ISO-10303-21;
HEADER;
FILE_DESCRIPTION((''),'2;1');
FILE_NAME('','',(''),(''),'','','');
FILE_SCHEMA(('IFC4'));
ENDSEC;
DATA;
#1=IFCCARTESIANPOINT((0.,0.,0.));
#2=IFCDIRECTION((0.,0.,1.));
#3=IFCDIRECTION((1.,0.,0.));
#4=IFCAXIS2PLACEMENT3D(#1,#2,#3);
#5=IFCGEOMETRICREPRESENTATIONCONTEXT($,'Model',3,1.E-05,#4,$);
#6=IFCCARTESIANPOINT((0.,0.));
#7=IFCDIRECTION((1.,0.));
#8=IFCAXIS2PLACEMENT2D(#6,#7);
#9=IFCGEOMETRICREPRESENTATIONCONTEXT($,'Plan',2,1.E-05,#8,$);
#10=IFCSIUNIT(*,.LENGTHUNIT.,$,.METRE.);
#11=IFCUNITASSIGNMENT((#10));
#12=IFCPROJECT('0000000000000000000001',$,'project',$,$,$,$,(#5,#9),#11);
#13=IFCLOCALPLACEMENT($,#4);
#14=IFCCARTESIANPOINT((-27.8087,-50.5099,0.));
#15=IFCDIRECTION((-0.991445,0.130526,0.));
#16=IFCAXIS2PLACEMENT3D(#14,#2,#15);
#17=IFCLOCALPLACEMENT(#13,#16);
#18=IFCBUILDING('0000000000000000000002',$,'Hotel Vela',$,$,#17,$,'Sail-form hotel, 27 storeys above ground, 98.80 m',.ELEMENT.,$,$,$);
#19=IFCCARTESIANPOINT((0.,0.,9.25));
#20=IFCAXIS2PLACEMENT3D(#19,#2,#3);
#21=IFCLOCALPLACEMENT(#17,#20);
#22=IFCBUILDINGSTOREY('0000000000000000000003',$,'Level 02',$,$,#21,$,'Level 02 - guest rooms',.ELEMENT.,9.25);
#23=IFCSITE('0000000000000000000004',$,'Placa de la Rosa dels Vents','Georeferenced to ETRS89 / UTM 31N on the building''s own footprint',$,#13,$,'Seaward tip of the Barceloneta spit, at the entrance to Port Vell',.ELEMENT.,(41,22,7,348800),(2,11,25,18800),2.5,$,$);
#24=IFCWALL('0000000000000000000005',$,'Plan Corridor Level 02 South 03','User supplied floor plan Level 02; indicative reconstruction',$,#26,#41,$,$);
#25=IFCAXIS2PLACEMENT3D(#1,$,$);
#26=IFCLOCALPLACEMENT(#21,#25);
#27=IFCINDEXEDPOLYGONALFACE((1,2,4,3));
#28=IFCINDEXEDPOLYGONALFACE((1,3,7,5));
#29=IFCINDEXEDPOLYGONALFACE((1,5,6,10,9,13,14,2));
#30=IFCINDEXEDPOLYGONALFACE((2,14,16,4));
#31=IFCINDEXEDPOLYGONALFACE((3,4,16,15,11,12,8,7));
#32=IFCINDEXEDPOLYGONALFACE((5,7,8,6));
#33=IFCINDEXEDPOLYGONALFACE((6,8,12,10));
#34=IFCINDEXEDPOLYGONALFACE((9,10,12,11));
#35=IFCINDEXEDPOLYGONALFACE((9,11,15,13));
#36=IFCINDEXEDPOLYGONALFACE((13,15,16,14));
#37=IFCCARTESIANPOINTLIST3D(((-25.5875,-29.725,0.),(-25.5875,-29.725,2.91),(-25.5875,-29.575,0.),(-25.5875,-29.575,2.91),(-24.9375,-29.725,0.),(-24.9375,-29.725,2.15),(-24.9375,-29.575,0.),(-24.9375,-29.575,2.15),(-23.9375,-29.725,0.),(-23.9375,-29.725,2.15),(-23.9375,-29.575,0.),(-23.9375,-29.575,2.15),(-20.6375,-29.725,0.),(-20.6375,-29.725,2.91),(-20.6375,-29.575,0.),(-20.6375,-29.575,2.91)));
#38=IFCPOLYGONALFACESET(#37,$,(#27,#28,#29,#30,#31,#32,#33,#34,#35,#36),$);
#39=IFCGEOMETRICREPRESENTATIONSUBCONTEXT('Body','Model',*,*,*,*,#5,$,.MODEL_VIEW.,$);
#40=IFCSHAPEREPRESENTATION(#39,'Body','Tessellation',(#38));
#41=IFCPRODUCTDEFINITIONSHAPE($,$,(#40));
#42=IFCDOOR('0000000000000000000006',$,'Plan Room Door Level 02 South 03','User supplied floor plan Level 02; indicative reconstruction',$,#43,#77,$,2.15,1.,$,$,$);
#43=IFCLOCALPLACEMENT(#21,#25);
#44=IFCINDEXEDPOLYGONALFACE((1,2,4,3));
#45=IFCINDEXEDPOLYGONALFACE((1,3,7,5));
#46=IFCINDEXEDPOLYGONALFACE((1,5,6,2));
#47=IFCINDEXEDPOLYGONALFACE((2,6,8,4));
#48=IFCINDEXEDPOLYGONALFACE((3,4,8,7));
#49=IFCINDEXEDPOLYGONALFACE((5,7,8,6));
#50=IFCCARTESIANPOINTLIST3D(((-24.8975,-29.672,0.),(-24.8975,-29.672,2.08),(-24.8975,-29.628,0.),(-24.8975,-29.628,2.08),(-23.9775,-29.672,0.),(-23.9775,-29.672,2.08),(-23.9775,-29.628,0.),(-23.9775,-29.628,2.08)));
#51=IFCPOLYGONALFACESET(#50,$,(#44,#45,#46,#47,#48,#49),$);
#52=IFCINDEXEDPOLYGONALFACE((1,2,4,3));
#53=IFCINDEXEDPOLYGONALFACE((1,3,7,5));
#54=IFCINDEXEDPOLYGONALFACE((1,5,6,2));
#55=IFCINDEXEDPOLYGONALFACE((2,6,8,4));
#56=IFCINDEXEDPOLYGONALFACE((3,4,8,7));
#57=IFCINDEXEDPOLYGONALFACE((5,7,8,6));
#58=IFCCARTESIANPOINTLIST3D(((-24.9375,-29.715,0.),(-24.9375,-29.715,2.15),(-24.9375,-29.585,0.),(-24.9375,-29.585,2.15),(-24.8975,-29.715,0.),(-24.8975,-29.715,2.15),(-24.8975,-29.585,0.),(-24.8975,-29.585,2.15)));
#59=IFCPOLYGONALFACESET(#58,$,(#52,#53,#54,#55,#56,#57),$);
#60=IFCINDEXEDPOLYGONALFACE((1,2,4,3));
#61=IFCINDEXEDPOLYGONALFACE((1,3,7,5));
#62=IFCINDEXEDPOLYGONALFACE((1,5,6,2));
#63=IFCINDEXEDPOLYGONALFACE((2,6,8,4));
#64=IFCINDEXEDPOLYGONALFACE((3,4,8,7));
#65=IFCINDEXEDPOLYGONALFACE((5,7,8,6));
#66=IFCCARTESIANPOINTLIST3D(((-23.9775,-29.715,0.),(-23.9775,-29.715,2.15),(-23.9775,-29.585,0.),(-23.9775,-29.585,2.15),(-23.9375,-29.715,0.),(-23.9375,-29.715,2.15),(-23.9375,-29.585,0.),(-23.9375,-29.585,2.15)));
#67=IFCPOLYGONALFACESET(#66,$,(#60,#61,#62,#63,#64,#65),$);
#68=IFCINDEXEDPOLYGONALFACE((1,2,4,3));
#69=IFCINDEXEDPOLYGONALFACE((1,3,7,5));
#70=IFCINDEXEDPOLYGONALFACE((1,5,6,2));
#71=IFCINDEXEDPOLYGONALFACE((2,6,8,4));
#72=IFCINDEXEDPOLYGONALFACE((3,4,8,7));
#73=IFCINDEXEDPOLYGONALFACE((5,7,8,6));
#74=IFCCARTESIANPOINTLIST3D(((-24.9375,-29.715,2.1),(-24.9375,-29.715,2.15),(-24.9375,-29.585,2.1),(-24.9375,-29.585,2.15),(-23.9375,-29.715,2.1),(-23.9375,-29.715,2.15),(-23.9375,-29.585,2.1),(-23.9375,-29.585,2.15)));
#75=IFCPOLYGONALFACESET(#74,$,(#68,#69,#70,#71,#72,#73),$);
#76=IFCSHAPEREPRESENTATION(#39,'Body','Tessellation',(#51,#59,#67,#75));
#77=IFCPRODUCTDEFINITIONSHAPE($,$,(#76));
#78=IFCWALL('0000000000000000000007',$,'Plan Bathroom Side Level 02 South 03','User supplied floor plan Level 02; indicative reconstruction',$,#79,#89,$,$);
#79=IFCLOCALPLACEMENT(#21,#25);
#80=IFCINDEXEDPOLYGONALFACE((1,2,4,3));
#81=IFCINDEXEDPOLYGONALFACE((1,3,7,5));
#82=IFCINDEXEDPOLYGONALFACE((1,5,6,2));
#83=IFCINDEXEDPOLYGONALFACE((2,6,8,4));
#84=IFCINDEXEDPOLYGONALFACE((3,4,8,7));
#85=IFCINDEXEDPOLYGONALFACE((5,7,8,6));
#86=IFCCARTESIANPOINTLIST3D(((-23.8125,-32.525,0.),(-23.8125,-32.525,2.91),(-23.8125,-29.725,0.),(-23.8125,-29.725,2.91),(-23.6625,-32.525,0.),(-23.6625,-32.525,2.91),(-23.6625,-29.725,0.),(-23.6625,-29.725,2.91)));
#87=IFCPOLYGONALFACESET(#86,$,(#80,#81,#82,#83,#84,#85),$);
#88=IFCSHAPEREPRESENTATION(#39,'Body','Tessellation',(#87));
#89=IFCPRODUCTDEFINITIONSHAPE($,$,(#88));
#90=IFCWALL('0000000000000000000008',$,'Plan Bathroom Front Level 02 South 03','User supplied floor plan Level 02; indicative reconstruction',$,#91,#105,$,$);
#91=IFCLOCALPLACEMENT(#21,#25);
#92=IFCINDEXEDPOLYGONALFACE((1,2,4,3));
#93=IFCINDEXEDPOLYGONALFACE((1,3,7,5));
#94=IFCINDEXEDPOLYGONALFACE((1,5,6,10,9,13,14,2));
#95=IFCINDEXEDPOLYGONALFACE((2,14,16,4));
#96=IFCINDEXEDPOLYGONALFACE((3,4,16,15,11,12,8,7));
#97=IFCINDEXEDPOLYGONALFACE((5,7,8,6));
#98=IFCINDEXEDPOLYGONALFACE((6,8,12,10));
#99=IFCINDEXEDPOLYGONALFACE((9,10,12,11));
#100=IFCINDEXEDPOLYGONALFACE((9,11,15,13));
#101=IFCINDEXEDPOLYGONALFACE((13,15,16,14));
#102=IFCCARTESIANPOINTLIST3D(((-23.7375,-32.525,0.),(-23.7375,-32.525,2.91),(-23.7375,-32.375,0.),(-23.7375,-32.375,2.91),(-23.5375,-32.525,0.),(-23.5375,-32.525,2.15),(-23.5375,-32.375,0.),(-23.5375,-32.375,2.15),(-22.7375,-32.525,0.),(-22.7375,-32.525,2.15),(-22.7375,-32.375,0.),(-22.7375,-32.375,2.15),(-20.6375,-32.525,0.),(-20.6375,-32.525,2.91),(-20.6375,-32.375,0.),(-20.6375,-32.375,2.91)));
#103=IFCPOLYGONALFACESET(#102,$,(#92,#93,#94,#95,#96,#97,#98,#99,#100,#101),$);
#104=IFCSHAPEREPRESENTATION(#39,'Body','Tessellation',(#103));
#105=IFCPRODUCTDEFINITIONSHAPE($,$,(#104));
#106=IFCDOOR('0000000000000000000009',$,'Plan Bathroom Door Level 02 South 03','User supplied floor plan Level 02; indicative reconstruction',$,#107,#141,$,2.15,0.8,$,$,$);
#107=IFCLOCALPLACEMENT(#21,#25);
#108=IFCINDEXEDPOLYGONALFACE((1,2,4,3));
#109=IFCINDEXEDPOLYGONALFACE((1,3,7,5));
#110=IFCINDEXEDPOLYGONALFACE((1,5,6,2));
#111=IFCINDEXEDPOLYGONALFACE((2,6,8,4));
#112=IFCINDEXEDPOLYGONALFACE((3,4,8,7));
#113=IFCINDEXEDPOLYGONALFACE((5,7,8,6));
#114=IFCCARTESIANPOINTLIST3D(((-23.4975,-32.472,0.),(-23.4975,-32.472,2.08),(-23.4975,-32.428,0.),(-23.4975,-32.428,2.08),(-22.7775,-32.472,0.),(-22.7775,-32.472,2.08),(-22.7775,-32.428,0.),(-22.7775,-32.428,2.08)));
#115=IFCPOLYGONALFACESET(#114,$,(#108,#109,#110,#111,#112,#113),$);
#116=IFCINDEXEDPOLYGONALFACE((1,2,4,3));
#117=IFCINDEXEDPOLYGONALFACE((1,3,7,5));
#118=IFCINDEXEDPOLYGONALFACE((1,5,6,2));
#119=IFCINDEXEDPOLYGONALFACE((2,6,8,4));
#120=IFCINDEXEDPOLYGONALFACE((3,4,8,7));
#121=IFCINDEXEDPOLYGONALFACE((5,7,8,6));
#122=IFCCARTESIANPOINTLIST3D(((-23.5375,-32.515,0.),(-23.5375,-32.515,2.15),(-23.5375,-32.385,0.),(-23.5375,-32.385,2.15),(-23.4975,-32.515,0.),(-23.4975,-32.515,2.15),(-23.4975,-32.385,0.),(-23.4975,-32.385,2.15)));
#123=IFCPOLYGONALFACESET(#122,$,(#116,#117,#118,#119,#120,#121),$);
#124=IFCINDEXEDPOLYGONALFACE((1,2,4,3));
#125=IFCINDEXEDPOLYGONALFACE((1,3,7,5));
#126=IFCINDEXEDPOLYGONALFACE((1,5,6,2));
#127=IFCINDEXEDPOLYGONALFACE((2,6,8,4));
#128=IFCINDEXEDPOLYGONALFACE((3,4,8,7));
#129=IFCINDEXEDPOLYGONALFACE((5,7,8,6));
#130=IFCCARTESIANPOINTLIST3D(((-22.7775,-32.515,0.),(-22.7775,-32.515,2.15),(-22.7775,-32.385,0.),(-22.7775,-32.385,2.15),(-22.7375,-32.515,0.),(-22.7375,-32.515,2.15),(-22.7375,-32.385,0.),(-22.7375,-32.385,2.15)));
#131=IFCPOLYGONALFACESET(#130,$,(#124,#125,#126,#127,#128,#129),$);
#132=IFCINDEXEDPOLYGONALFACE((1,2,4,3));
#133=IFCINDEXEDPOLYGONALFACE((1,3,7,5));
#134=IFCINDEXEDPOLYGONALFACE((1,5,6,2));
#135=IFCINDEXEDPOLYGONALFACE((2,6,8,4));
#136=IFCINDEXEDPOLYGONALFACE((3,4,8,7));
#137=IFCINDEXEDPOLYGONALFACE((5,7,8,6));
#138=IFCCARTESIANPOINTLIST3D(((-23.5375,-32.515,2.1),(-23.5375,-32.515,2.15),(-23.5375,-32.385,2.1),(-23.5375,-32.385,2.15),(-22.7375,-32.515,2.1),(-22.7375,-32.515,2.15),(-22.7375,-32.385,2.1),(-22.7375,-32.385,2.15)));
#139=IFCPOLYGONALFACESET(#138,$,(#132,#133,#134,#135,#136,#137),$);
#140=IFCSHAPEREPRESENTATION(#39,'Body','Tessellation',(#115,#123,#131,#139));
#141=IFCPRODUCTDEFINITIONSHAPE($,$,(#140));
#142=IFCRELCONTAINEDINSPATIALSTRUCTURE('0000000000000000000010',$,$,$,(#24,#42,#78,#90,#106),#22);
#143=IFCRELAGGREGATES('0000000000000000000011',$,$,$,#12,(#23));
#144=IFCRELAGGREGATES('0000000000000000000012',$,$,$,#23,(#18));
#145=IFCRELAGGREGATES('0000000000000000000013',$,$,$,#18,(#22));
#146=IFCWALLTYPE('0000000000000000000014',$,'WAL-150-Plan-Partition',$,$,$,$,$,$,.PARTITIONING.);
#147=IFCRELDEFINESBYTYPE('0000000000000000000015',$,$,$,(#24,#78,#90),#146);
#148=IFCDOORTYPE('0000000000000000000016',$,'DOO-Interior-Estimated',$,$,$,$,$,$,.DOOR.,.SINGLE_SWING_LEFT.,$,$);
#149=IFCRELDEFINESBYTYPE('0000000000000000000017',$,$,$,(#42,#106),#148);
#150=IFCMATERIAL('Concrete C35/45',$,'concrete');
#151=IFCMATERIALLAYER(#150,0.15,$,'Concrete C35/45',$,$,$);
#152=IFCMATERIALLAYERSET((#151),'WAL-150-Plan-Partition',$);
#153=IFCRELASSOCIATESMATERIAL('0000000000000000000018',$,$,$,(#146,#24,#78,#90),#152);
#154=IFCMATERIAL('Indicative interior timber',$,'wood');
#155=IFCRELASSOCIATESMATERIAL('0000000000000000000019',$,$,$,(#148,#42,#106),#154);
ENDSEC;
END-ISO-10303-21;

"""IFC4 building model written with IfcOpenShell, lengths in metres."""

from ifc_helpers import new_model, si_unit, frame, origin_with_axes, origin_2d_with_axis, place, context, subcontext, project, spatial, line, indexed_curve, outline, extrude, material, layer, layer_set, layer_usage, type_object, element, fill, save


model = new_model("IFC4")

# Units and contexts
model_context = context("Model", 3, precision=1e-05, world=origin_with_axes())
plan_context = context("Plan", 2, precision=1e-05, world=origin_2d_with_axis())
body_context = subcontext(model_context, "Body", "Model", "MODEL_VIEW")
ifc_project = project(units=[si_unit("LENGTHUNIT", "METRE")], contexts=[model_context, plan_context])

# Site, building, storey
site_placement = place(None, origin_with_axes())
site = spatial("IfcSite", under=ifc_project, at=site_placement, Name="Placa de la Rosa dels Vents", Description="Georeferenced to ETRS89 / UTM 31N on the building's own footprint", LongName="Seaward tip of the Barceloneta spit, at the entrance to Port Vell", CompositionType="ELEMENT", RefLatitude=(41, 22, 7, 348800), RefLongitude=(2, 11, 25, 18800), RefElevation=2.5)
building_placement = place(site_placement, frame((-27.8087, -50.5099, 0.0), z_axis=(0.0, 0.0, 1.0), x_axis=(-0.991445, 0.130526, 0.0)))
building = spatial("IfcBuilding", under=site, at=building_placement, Name="Hotel Vela", LongName="Sail-form hotel, 27 storeys above ground, 98.80 m", CompositionType="ELEMENT")
storey_placement = place(building_placement, frame((0.0, 0.0, 9.25), z_axis=(0.0, 0.0, 1.0), x_axis=(1.0, 0.0, 0.0)))
storey = spatial("IfcBuildingStorey", under=building, at=storey_placement, Name="Level 02", LongName="Level 02 - guest rooms", CompositionType="ELEMENT", Elevation=9.25)

# Wall, opening, door
ifc_material_1 = material(Name="Concrete C35/45", Category="concrete")
ifc_layer = layer(ifc_material_1, 0.15, Name="Concrete C35/45")
ifc_layer_set = layer_set([ifc_layer], Name="WAL-150-Plan-Partition")
ifc_layer_usage_1 = layer_usage(ifc_layer_set, "AXIS2", "POSITIVE", 0.0)
wall_type = type_object("IfcWallType", Name="WAL-150-Plan-Partition", PredefinedType="PARTITIONING", material=ifc_layer_set)
wall_1_placement = place(storey_placement, frame((-25.5875, -29.725, 0.0), z_axis=(0.0, 0.0, 1.0), x_axis=(1.0, 0.0, 0.0)))
wall_1 = element("IfcWall", 1, at=wall_1_placement, inside=storey, type_object=wall_type, material=ifc_layer_usage_1, Name="Plan Corridor Level 02 South 03", Description="User supplied floor plan Level 02; indicative reconstruction", context=body_context, shape_type="SweptSolid", body=[
    extrude(outline(indexed_curve([(0.0, 0.0), (4.95, 0.0), (4.95, 0.15), (0.0, 0.15)], segments=[line(1, 2, 3, 4, 1)])), origin_with_axes(), (0.0, 0.0, 1.0), 2.91),
])
opening_1_placement = place(wall_1_placement, frame((0.65, -0.085, 0.0), z_axis=(0.0, 0.0, 1.0), x_axis=(1.0, 0.0, 0.0)))
opening_1 = element("IfcOpeningElement", 2, at=opening_1_placement, cuts=wall_1, PredefinedType="OPENING", context=body_context, shape_type="SweptSolid", body=[
    extrude(outline(indexed_curve([(0.0, 0.0), (1.0, 0.0), (1.0, 0.32), (0.0, 0.32)], segments=[line(1, 2, 3, 4, 1)])), origin_with_axes(), (0.0, 0.0, 1.0), 2.15),
])
ifc_material_2 = material(Name="Indicative interior timber", Category="wood")
door_type = type_object("IfcDoorType", Name="DOO-Interior-Estimated", OperationType="SINGLE_SWING_LEFT", PredefinedType="DOOR", material=ifc_material_2)
door_1_placement = place(storey_placement, frame((0.0, 0.0, -9.25), z_axis=(0.0, 0.0, 1.0), x_axis=(1.0, 0.0, 0.0)))
door_1 = element("IfcDoor", 3, at=door_1_placement, inside=storey, type_object=door_type, material=ifc_material_2, Name="Plan Room Door Level 02 South 03", Description="User supplied floor plan Level 02; indicative reconstruction", OverallHeight=2.15, OverallWidth=1.0, context=body_context, shape_type="SweptSolid", body=[
    extrude(outline(indexed_curve([(0.0, 0.0), (0.92, 0.0), (0.92, 0.044), (0.0, 0.044)], segments=[line(1, 2, 3, 4, 1)])), frame((-24.8975, -29.672, 9.25), z_axis=(0.0, 0.0, 1.0), x_axis=(1.0, 0.0, 0.0)), (0.0, 0.0, 1.0), 2.08),
    extrude(outline(indexed_curve([(0.0, 0.0), (0.04, 0.0), (0.04, 0.13), (0.0, 0.13)], segments=[line(1, 2, 3, 4, 1)])), frame((-24.9375, -29.715, 9.25), z_axis=(0.0, 0.0, 1.0), x_axis=(1.0, 0.0, 0.0)), (0.0, 0.0, 1.0), 2.15),
    extrude(outline(indexed_curve([(0.0, 0.0), (0.04, 0.0), (0.04, 0.13), (0.0, 0.13)], segments=[line(1, 2, 3, 4, 1)])), frame((-23.9775, -29.715, 9.25), z_axis=(0.0, 0.0, 1.0), x_axis=(1.0, 0.0, 0.0)), (0.0, 0.0, 1.0), 2.15),
    extrude(outline(indexed_curve([(0.0, 0.0), (1.0, 0.0), (1.0, 0.13), (0.0, 0.13)], segments=[line(1, 2, 3, 4, 1)])), frame((-24.9375, -29.715, 11.35), z_axis=(0.0, 0.0, 1.0), x_axis=(1.0, 0.0, 0.0)), (0.0, 0.0, 1.0), 0.05),
])
fill(opening_1, door_1)

# Wall
ifc_layer_usage_2 = layer_usage(ifc_layer_set, "AXIS2", "POSITIVE", 0.0)
wall_2_placement = place(storey_placement, frame((-23.8125, -32.525, 0.0), z_axis=(0.0, 0.0, 1.0), x_axis=(1.0, 0.0, 0.0)))
element("IfcWall", 4, at=wall_2_placement, inside=storey, type_object=wall_type, material=ifc_layer_usage_2, Name="Plan Bathroom Side Level 02 South 03", Description="User supplied floor plan Level 02; indicative reconstruction", context=body_context, shape_type="SweptSolid", body=[
    extrude(outline(indexed_curve([(0.0, 0.0), (0.15, 0.0), (0.15, 2.8), (0.0, 2.8)], segments=[line(1, 2, 3, 4, 1)])), origin_with_axes(), (0.0, 0.0, 1.0), 2.91),
])

# Wall, opening, door
ifc_layer_usage_3 = layer_usage(ifc_layer_set, "AXIS2", "POSITIVE", 0.0)
wall_3_placement = place(storey_placement, frame((-23.7375, -32.525, 0.0), z_axis=(0.0, 0.0, 1.0), x_axis=(1.0, 0.0, 0.0)))
wall_3 = element("IfcWall", 5, at=wall_3_placement, inside=storey, type_object=wall_type, material=ifc_layer_usage_3, Name="Plan Bathroom Front Level 02 South 03", Description="User supplied floor plan Level 02; indicative reconstruction", context=body_context, shape_type="SweptSolid", body=[
    extrude(outline(indexed_curve([(0.0, 0.0), (3.1, 0.0), (3.1, 0.15), (0.0, 0.15)], segments=[line(1, 2, 3, 4, 1)])), origin_with_axes(), (0.0, 0.0, 1.0), 2.91),
])
opening_2_placement = place(wall_3_placement, frame((0.2, -0.085, 0.0), z_axis=(0.0, 0.0, 1.0), x_axis=(1.0, 0.0, 0.0)))
opening_2 = element("IfcOpeningElement", 6, at=opening_2_placement, cuts=wall_3, PredefinedType="OPENING", context=body_context, shape_type="SweptSolid", body=[
    extrude(outline(indexed_curve([(0.0, 0.0), (0.8, 0.0), (0.8, 0.32), (0.0, 0.32)], segments=[line(1, 2, 3, 4, 1)])), origin_with_axes(), (0.0, 0.0, 1.0), 2.15),
])
door_2_placement = place(storey_placement, frame((0.0, 0.0, -9.25), z_axis=(0.0, 0.0, 1.0), x_axis=(1.0, 0.0, 0.0)))
door_2 = element("IfcDoor", 7, at=door_2_placement, inside=storey, type_object=door_type, material=ifc_material_2, Name="Plan Bathroom Door Level 02 South 03", Description="User supplied floor plan Level 02; indicative reconstruction", OverallHeight=2.15, OverallWidth=0.8, context=body_context, shape_type="SweptSolid", body=[
    extrude(outline(indexed_curve([(0.0, 0.0), (0.72, 0.0), (0.72, 0.044), (0.0, 0.044)], segments=[line(1, 2, 3, 4, 1)])), frame((-23.4975, -32.472, 9.25), z_axis=(0.0, 0.0, 1.0), x_axis=(1.0, 0.0, 0.0)), (0.0, 0.0, 1.0), 2.08),
    extrude(outline(indexed_curve([(0.0, 0.0), (0.04, 0.0), (0.04, 0.13), (0.0, 0.13)], segments=[line(1, 2, 3, 4, 1)])), frame((-23.5375, -32.515, 9.25), z_axis=(0.0, 0.0, 1.0), x_axis=(1.0, 0.0, 0.0)), (0.0, 0.0, 1.0), 2.15),
    extrude(outline(indexed_curve([(0.0, 0.0), (0.04, 0.0), (0.04, 0.13), (0.0, 0.13)], segments=[line(1, 2, 3, 4, 1)])), frame((-22.7775, -32.515, 9.25), z_axis=(0.0, 0.0, 1.0), x_axis=(1.0, 0.0, 0.0)), (0.0, 0.0, 1.0), 2.15),
    extrude(outline(indexed_curve([(0.0, 0.0), (0.8, 0.0), (0.8, 0.13), (0.0, 0.13)], segments=[line(1, 2, 3, 4, 1)])), frame((-23.5375, -32.515, 11.35), z_axis=(0.0, 0.0, 1.0), x_axis=(1.0, 0.0, 0.0)), (0.0, 0.0, 1.0), 0.05),
])
fill(opening_2, door_2)

save(model, "model.ifc")
